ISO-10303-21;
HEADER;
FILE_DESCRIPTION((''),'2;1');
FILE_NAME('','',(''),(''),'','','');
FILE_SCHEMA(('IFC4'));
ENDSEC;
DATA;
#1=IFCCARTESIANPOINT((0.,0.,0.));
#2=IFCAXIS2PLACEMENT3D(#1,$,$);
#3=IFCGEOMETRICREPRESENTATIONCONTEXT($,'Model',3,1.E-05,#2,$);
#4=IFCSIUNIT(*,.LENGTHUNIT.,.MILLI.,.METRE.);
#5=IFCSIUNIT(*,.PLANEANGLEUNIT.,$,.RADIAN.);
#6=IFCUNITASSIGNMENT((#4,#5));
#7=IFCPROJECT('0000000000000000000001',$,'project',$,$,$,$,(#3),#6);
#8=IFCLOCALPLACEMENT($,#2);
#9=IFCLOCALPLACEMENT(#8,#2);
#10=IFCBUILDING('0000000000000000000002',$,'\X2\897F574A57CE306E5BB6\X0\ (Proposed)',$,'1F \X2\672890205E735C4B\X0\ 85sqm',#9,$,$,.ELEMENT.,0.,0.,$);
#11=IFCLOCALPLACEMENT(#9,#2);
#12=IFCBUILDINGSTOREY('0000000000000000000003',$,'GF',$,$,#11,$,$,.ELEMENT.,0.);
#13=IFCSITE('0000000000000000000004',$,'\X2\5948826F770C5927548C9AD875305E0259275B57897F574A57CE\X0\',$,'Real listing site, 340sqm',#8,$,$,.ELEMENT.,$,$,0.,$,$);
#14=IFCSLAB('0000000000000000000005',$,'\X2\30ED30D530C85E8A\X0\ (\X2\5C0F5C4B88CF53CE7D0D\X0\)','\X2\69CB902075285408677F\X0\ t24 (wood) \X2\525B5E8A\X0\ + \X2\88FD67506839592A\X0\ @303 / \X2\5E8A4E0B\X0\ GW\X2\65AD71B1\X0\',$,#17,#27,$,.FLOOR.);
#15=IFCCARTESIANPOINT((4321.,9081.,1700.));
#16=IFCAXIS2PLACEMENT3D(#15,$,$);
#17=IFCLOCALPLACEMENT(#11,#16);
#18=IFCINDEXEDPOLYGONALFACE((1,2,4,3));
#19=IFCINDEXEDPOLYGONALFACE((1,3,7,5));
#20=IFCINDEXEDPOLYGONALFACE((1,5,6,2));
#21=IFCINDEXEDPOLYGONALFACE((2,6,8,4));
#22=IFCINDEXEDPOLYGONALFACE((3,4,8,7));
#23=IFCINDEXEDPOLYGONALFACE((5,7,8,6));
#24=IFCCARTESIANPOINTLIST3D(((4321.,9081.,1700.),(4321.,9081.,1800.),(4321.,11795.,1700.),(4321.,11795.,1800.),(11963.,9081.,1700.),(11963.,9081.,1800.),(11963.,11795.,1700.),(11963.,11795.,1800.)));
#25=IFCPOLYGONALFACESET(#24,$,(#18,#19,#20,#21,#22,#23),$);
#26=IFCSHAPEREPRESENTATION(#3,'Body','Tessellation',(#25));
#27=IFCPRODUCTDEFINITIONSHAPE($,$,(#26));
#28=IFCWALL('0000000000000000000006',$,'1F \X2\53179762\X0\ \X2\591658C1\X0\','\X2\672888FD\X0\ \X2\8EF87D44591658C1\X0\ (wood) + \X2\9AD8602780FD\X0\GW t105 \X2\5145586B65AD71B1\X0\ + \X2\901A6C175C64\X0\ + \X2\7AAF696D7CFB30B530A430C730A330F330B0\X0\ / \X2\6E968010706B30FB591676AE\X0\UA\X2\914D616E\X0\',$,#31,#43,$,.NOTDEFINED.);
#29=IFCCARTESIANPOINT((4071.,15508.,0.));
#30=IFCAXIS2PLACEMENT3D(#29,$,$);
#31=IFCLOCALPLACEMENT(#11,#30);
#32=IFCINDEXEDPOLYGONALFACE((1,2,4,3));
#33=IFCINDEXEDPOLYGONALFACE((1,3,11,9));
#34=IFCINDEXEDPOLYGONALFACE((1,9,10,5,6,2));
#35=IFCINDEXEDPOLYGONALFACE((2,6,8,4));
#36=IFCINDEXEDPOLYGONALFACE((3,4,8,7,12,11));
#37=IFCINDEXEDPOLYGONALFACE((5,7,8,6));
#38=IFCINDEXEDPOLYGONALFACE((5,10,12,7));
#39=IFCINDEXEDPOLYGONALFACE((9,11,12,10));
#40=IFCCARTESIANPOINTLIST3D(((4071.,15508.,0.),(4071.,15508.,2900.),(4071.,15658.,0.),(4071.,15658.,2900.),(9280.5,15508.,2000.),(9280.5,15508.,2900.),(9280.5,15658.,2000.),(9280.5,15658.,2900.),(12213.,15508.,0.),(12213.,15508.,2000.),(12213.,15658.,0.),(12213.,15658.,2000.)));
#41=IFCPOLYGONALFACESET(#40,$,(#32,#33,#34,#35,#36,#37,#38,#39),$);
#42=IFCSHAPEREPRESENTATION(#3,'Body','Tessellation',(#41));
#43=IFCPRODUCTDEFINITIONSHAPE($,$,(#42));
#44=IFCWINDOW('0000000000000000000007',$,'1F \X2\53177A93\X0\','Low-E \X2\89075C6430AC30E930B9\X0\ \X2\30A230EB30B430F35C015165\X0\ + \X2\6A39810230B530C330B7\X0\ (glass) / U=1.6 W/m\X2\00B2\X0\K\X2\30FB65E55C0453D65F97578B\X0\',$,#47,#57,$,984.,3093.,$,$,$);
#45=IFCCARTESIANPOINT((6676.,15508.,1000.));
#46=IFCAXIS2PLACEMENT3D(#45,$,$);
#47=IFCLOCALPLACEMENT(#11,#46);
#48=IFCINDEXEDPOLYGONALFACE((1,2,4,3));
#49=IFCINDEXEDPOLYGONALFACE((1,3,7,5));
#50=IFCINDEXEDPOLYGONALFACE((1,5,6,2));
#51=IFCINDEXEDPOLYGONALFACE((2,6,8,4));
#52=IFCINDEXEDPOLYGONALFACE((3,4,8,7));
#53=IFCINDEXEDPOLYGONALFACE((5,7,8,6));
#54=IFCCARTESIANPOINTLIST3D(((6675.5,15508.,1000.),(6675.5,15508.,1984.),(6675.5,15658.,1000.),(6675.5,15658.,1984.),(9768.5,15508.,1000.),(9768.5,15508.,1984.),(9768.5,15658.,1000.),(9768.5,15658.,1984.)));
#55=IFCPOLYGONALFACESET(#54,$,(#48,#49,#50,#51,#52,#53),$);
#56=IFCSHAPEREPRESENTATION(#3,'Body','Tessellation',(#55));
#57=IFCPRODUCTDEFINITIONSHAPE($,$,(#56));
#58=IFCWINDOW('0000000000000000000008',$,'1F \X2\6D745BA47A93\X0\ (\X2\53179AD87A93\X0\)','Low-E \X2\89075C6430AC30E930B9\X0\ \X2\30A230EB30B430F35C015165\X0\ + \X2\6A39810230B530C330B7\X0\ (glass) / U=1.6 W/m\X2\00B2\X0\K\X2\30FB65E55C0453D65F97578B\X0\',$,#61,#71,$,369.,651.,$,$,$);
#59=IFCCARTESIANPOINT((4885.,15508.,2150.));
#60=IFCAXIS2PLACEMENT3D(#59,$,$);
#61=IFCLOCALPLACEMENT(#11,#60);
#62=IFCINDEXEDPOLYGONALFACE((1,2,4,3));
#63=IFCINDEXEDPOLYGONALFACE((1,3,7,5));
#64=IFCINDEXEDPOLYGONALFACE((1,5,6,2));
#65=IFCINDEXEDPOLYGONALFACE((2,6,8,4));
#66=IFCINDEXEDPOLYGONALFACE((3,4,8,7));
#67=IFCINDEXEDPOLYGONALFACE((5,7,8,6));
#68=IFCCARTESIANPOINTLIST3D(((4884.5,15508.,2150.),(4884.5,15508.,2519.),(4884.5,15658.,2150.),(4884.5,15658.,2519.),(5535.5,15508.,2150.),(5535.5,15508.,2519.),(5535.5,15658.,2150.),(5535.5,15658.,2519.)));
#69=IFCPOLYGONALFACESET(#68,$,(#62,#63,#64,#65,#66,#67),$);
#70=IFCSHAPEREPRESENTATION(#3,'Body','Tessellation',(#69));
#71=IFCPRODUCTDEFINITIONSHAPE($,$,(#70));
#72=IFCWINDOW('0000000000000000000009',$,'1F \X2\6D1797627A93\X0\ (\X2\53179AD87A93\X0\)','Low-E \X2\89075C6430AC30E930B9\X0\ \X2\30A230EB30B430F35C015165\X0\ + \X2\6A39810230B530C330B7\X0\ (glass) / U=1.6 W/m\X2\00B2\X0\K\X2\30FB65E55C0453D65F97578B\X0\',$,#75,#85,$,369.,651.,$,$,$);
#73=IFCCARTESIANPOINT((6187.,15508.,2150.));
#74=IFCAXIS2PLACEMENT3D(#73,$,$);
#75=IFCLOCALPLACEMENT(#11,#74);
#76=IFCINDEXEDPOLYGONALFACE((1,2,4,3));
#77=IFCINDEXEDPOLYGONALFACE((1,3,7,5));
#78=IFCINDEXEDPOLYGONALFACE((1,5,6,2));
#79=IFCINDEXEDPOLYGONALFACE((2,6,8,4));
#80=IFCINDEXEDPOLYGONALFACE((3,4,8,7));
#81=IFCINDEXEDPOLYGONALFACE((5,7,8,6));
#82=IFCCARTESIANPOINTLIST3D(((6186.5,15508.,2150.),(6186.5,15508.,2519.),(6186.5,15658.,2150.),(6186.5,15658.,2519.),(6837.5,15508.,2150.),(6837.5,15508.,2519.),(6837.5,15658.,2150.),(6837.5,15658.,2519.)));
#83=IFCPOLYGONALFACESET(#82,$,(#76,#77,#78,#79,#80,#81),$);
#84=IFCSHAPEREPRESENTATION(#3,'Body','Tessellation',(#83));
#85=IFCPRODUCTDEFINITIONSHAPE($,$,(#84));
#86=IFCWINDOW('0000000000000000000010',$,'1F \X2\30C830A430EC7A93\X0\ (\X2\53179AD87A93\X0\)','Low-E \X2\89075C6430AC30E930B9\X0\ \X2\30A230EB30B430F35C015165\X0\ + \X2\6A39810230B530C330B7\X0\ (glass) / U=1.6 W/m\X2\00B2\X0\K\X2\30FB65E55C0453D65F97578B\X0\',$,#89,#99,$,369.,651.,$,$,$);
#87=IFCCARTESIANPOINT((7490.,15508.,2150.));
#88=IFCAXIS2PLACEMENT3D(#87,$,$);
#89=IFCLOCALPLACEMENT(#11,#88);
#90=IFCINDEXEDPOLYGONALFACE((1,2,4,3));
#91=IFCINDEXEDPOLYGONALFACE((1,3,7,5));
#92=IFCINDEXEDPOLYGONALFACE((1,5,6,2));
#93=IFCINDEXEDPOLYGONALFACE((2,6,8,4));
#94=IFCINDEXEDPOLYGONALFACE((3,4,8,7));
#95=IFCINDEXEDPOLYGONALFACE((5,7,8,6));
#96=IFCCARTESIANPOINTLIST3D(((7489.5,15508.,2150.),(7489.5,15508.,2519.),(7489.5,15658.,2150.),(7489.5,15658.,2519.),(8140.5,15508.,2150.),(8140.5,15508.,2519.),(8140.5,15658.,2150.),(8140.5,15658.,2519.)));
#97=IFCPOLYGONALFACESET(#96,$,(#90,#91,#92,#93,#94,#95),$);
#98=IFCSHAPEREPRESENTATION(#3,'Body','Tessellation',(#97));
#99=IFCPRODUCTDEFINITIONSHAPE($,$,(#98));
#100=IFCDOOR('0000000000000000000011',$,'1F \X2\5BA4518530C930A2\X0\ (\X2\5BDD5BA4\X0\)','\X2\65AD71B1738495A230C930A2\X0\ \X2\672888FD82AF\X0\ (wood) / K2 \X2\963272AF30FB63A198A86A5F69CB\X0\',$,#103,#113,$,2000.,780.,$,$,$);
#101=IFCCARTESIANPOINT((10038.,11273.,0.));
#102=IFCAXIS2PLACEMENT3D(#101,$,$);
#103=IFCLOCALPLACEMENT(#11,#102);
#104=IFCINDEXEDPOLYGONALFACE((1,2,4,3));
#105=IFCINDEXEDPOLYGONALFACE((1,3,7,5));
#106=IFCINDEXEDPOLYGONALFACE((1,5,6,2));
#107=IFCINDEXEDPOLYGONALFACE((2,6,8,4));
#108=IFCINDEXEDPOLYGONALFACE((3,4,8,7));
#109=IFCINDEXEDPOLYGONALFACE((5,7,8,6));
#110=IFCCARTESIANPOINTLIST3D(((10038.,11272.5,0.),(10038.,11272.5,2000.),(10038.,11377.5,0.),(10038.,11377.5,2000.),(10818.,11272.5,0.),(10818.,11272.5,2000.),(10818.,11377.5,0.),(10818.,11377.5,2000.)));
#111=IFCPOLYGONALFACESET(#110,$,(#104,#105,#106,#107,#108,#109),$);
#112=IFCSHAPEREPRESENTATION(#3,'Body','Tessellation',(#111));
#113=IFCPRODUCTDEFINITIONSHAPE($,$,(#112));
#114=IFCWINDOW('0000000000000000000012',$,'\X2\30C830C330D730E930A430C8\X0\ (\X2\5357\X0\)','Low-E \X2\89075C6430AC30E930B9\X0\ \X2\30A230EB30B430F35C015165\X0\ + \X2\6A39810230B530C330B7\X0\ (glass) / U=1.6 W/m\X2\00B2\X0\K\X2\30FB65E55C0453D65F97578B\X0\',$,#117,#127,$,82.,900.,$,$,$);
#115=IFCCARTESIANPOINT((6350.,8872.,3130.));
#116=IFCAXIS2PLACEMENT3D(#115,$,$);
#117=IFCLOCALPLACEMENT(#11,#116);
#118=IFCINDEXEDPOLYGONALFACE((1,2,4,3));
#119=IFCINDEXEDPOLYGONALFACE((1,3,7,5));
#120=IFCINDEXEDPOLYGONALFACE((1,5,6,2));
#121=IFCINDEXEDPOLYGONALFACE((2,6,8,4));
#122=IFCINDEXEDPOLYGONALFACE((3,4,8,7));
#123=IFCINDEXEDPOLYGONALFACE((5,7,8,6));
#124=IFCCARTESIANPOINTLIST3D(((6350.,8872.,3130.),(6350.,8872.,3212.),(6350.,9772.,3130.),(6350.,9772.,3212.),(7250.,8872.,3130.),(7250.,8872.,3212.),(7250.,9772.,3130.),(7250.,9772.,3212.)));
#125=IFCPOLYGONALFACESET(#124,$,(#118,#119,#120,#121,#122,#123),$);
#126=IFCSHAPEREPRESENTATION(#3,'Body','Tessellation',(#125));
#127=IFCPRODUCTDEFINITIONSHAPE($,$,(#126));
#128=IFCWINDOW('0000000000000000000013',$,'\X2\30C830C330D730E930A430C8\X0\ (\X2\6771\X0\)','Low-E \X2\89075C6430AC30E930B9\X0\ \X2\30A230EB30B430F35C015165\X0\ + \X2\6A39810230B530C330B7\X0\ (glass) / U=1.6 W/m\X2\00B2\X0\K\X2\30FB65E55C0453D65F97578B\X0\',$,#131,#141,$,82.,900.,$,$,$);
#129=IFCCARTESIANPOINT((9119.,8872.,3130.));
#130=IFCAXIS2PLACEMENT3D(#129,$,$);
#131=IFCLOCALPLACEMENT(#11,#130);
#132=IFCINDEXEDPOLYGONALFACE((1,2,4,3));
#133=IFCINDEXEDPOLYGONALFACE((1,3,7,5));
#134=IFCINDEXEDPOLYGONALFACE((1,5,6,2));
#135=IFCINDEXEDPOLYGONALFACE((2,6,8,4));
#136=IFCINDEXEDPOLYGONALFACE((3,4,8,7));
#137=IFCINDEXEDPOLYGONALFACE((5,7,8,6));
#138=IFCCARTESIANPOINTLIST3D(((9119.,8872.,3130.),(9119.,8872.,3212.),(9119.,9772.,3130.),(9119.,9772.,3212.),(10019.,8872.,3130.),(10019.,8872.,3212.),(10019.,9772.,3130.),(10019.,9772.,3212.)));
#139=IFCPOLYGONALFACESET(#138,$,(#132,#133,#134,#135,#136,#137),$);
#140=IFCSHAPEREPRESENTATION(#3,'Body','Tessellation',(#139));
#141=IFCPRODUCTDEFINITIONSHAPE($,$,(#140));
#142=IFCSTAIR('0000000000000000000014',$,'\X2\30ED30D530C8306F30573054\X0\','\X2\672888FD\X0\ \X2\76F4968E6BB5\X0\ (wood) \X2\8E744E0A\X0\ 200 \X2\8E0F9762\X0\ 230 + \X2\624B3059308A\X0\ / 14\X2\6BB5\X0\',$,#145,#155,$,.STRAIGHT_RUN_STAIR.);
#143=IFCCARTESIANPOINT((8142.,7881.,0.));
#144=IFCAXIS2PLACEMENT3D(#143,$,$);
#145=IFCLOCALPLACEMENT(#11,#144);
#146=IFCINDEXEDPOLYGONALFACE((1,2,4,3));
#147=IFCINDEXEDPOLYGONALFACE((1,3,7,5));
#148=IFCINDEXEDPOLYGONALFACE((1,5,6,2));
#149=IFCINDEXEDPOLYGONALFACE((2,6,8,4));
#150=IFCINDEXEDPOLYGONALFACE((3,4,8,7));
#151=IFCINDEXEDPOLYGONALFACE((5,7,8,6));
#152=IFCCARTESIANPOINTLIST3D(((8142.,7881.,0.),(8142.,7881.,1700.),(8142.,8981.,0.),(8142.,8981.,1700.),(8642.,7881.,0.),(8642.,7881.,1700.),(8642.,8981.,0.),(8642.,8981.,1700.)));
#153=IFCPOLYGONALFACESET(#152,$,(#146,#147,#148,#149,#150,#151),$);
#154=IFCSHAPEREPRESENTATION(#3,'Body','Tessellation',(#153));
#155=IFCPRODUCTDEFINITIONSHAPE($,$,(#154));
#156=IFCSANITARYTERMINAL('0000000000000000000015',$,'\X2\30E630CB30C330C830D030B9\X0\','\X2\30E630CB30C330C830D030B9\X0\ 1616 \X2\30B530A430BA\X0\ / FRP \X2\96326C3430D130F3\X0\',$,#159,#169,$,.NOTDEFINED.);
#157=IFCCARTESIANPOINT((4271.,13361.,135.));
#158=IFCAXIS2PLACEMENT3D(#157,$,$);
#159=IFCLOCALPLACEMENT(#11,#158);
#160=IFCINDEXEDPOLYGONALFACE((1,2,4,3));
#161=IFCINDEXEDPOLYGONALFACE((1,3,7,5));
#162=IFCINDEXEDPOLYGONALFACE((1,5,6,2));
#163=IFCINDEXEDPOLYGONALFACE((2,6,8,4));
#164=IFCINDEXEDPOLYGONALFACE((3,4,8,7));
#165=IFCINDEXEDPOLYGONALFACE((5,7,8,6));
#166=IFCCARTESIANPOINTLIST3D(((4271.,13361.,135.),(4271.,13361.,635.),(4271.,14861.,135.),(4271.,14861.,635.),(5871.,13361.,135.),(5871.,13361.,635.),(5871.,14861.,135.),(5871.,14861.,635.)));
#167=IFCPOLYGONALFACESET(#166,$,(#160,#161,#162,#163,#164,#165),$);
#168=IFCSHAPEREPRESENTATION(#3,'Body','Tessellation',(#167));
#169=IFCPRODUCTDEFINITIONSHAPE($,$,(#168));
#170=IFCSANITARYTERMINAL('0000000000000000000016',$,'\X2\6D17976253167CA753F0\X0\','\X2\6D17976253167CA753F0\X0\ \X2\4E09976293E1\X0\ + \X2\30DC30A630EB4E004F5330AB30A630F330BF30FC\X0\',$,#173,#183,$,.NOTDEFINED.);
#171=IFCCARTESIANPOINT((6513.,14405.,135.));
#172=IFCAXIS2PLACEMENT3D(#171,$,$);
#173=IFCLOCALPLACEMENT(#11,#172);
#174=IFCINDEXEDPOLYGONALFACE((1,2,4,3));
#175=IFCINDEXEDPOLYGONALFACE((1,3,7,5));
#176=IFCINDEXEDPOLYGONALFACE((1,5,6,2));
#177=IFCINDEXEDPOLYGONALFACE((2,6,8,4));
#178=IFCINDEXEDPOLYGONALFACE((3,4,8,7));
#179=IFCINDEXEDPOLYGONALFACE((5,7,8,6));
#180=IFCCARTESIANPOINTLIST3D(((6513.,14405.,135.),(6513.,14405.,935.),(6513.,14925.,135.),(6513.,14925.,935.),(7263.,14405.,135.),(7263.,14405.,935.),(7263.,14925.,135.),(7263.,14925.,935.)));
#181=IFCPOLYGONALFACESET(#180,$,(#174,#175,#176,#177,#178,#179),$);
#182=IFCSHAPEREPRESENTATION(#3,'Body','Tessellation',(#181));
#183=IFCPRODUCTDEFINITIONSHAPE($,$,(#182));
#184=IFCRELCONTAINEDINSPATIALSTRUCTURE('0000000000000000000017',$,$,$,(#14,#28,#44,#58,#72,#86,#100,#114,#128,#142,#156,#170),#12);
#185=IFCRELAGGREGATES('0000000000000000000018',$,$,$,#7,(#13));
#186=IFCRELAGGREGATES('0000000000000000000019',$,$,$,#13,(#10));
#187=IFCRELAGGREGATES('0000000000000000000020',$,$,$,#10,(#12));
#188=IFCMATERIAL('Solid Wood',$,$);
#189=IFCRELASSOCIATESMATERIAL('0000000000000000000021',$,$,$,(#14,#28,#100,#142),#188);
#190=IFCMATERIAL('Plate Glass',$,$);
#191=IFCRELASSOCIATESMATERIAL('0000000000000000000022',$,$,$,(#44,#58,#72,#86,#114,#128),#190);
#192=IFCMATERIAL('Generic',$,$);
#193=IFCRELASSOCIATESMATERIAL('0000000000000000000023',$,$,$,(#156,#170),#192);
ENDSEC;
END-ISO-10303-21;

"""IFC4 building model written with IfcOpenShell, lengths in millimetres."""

from ifc_helpers import new_model, si_unit, frame, frame_2d, origin, place, context, project, spatial, rectangle, extrude, material, element, fill, save


model = new_model("IFC4")

# Units and contexts
model_context = context("Model", 3, precision=1e-05, world=origin())
ifc_project = project(units=[si_unit("LENGTHUNIT", "METRE", prefix="MILLI"), si_unit("PLANEANGLEUNIT", "RADIAN")], contexts=[model_context])

# Site, building, storey
site_placement = place(None, origin())
site = spatial("IfcSite", under=ifc_project, at=site_placement, Name="奈良県大和高田市大字西坊城", ObjectType="Real listing site, 340sqm", CompositionType="ELEMENT", RefElevation=0.0)
building_placement = place(site_placement, origin())
building = spatial("IfcBuilding", under=site, at=building_placement, Name="西坊城の家 (Proposed)", ObjectType="1F 木造平屋 85sqm", CompositionType="ELEMENT", ElevationOfRefHeight=0.0, ElevationOfTerrain=0.0)
storey_placement = place(building_placement, origin())
storey = spatial("IfcBuildingStorey", under=building, at=storey_placement, Name="GF", CompositionType="ELEMENT", Elevation=0.0)

# Slab
ifc_material_1 = material(Name="Solid Wood")
slab_placement = place(storey_placement, frame((4321.0, 9081.0, 1700.0)))
element("IfcSlab", 1, at=slab_placement, inside=storey, material=ifc_material_1, Name="ロフト床 (小屋裏収納)", Description="構造用合板 t24 (wood) 剛床 + 製材根太 @303 / 床下 GW断熱", PredefinedType="FLOOR", context=model_context, shape_type="SweptSolid", body=[
    extrude(rectangle(XDim=7642.0, YDim=2714.0, at=frame_2d((3821.0, 1357.0))), frame((4321.0, 9081.0, 1700.0)), (0.0, 0.0, 1.0), 100.0),
])

# Wall, openings, windows
wall_1_placement = place(storey_placement, frame((4071.0, 15508.0, 0.0)))
wall_1 = element("IfcWall", 2, at=wall_1_placement, inside=storey, material=ifc_material_1, Name="1F 北面 外壁", Description="木製 軸組外壁 (wood) + 高性能GW t105 充填断熱 + 通気層 + 窯業系サイディング / 準耐火・外皮UA配慮", PredefinedType="NOTDEFINED", context=model_context, shape_type="SweptSolid", body=[
    extrude(rectangle(XDim=8142.0, YDim=150.0, at=frame_2d((4071.0, 75.0))), frame((4071.0, 15508.0, 0.0)), (0.0, 0.0, 1.0), 2900.0),
])
opening_1_placement = place(storey_placement, frame((6676.0, 15508.0, 1000.0)))
opening_1 = element("IfcOpeningElement", 3, at=opening_1_placement, cuts=wall_1, PredefinedType="NOTDEFINED", context=model_context, shape_type="SweptSolid", body=[
    extrude(rectangle(XDim=3093.0, YDim=150.0, at=frame_2d((1546.0, 75.0))), frame((6676.0, 15508.0, 1000.0)), (0.0, 0.0, 1.0), 984.0),
])
opening_2_placement = place(storey_placement, frame((4885.0, 15508.0, 2150.0)))
opening_2 = element("IfcOpeningElement", 4, at=opening_2_placement, cuts=wall_1, PredefinedType="NOTDEFINED", context=model_context, shape_type="SweptSolid", body=[
    extrude(rectangle(XDim=651.0, YDim=150.0, at=frame_2d((325.0, 75.0))), frame((4885.0, 15508.0, 2150.0)), (0.0, 0.0, 1.0), 369.0),
])
opening_3_placement = place(storey_placement, frame((6187.0, 15508.0, 2150.0)))
opening_3 = element("IfcOpeningElement", 5, at=opening_3_placement, cuts=wall_1, PredefinedType="NOTDEFINED", context=model_context, shape_type="SweptSolid", body=[
    extrude(rectangle(XDim=651.0, YDim=150.0, at=frame_2d((325.0, 75.0))), frame((6187.0, 15508.0, 2150.0)), (0.0, 0.0, 1.0), 369.0),
])
opening_4_placement = place(storey_placement, frame((7490.0, 15508.0, 2150.0)))
opening_4 = element("IfcOpeningElement", 6, at=opening_4_placement, cuts=wall_1, PredefinedType="NOTDEFINED", context=model_context, shape_type="SweptSolid", body=[
    extrude(rectangle(XDim=651.0, YDim=150.0, at=frame_2d((325.0, 75.0))), frame((7490.0, 15508.0, 2150.0)), (0.0, 0.0, 1.0), 369.0),
])
ifc_material_2 = material(Name="Plate Glass")
window_1_placement = place(storey_placement, frame((6676.0, 15508.0, 1000.0)))
window_1 = element("IfcWindow", 7, at=window_1_placement, inside=storey, material=ifc_material_2, Name="1F 北窓", Description="Low-E 複層ガラス アルゴン封入 + 樹脂サッシ (glass) / U=1.6 W/m²K・日射取得型", OverallHeight=984.0, OverallWidth=3093.0, context=model_context, shape_type="SweptSolid", body=[
    extrude(rectangle(XDim=3093.0, YDim=150.0, at=frame_2d((1546.0, 75.0))), frame((6676.0, 15508.0, 1000.0)), (0.0, 0.0, 1.0), 984.0),
])
fill(opening_1, window_1)
window_2_placement = place(storey_placement, frame((4885.0, 15508.0, 2150.0)))
window_2 = element("IfcWindow", 8, at=window_2_placement, inside=storey, material=ifc_material_2, Name="1F 浴室窓 (北高窓)", Description="Low-E 複層ガラス アルゴン封入 + 樹脂サッシ (glass) / U=1.6 W/m²K・日射取得型", OverallHeight=369.0, OverallWidth=651.0, context=model_context, shape_type="SweptSolid", body=[
    extrude(rectangle(XDim=651.0, YDim=150.0, at=frame_2d((325.0, 75.0))), frame((4885.0, 15508.0, 2150.0)), (0.0, 0.0, 1.0), 369.0),
])
fill(opening_2, window_2)
window_3_placement = place(storey_placement, frame((6187.0, 15508.0, 2150.0)))
window_3 = element("IfcWindow", 9, at=window_3_placement, inside=storey, material=ifc_material_2, Name="1F 洗面窓 (北高窓)", Description="Low-E 複層ガラス アルゴン封入 + 樹脂サッシ (glass) / U=1.6 W/m²K・日射取得型", OverallHeight=369.0, OverallWidth=651.0, context=model_context, shape_type="SweptSolid", body=[
    extrude(rectangle(XDim=651.0, YDim=150.0, at=frame_2d((325.0, 75.0))), frame((6187.0, 15508.0, 2150.0)), (0.0, 0.0, 1.0), 369.0),
])
fill(opening_3, window_3)
window_4_placement = place(storey_placement, frame((7490.0, 15508.0, 2150.0)))
window_4 = element("IfcWindow", 10, at=window_4_placement, inside=storey, material=ifc_material_2, Name="1F トイレ窓 (北高窓)", Description="Low-E 複層ガラス アルゴン封入 + 樹脂サッシ (glass) / U=1.6 W/m²K・日射取得型", OverallHeight=369.0, OverallWidth=651.0, context=model_context, shape_type="SweptSolid", body=[
    extrude(rectangle(XDim=651.0, YDim=150.0, at=frame_2d((325.0, 75.0))), frame((7490.0, 15508.0, 2150.0)), (0.0, 0.0, 1.0), 369.0),
])
fill(opening_4, window_4)

# Door
door_1_placement = place(storey_placement, frame((10038.0, 11273.0, 0.0)))
element("IfcDoor", 11, at=door_1_placement, inside=storey, material=ifc_material_1, Name="1F 室内ドア (寝室)", Description="断熱玄関ドア 木製芯 (wood) / K2 防犯・採風機構", OverallHeight=2000.0, OverallWidth=780.0, context=model_context, shape_type="SweptSolid", body=[
    extrude(rectangle(XDim=780.0, YDim=105.0, at=frame_2d((390.0, 52.0))), frame((10038.0, 11273.0, 0.0)), (0.0, 0.0, 1.0), 2000.0),
])

# Windows
window_5_placement = place(storey_placement, frame((6350.0, 8872.0, 3130.0)))
element("IfcWindow", 12, at=window_5_placement, inside=storey, material=ifc_material_2, Name="トップライト (南)", Description="Low-E 複層ガラス アルゴン封入 + 樹脂サッシ (glass) / U=1.6 W/m²K・日射取得型", OverallHeight=82.0, OverallWidth=900.0, context=model_context, shape_type="SweptSolid", body=[
    extrude(rectangle(XDim=900.0, YDim=900.0, at=frame_2d((450.0, 450.0))), frame((6350.0, 8872.0, 3130.0)), (0.0, 0.0, 1.0), 82.0),
])
window_6_placement = place(storey_placement, frame((9119.0, 8872.0, 3130.0)))
element("IfcWindow", 13, at=window_6_placement, inside=storey, material=ifc_material_2, Name="トップライト (東)", Description="Low-E 複層ガラス アルゴン封入 + 樹脂サッシ (glass) / U=1.6 W/m²K・日射取得型", OverallHeight=82.0, OverallWidth=900.0, context=model_context, shape_type="SweptSolid", body=[
    extrude(rectangle(XDim=900.0, YDim=900.0, at=frame_2d((450.0, 450.0))), frame((9119.0, 8872.0, 3130.0)), (0.0, 0.0, 1.0), 82.0),
])

# Stair
stair_placement = place(storey_placement, frame((8142.0, 7881.0, 0.0)))
element("IfcStair", 14, at=stair_placement, inside=storey, material=ifc_material_1, Name="ロフトはしご", Description="木製 直階段 (wood) 蹴上 200 踏面 230 + 手すり / 14段", PredefinedType="STRAIGHT_RUN_STAIR", context=model_context, shape_type="SweptSolid", body=[
    extrude(rectangle(XDim=500.0, YDim=1100.0, at=frame_2d((250.0, 550.0))), frame((8142.0, 7881.0, 0.0)), (0.0, 0.0, 1.0), 1700.0),
])

# Sanitary terminals
ifc_material_3 = material(Name="Generic")
sanitary_terminal_1_placement = place(storey_placement, frame((4271.0, 13361.0, 135.0)))
element("IfcSanitaryTerminal", 15, at=sanitary_terminal_1_placement, inside=storey, material=ifc_material_3, Name="ユニットバス", Description="ユニットバス 1616 サイズ / FRP 防水パン", PredefinedType="NOTDEFINED", context=model_context, shape_type="SweptSolid", body=[
    extrude(rectangle(XDim=1600.0, YDim=1500.0, at=frame_2d((800.0, 750.0))), frame((4271.0, 13361.0, 135.0)), (0.0, 0.0, 1.0), 500.0),
])
sanitary_terminal_2_placement = place(storey_placement, frame((6513.0, 14405.0, 135.0)))
element("IfcSanitaryTerminal", 16, at=sanitary_terminal_2_placement, inside=storey, material=ifc_material_3, Name="洗面化粧台", Description="洗面化粧台 三面鏡 + ボウル一体カウンター", PredefinedType="NOTDEFINED", context=model_context, shape_type="SweptSolid", body=[
    extrude(rectangle(XDim=750.0, YDim=520.0, at=frame_2d((375.0, 260.0))), frame((6513.0, 14405.0, 135.0)), (0.0, 0.0, 1.0), 800.0),
])

save(model, "model.ifc")
